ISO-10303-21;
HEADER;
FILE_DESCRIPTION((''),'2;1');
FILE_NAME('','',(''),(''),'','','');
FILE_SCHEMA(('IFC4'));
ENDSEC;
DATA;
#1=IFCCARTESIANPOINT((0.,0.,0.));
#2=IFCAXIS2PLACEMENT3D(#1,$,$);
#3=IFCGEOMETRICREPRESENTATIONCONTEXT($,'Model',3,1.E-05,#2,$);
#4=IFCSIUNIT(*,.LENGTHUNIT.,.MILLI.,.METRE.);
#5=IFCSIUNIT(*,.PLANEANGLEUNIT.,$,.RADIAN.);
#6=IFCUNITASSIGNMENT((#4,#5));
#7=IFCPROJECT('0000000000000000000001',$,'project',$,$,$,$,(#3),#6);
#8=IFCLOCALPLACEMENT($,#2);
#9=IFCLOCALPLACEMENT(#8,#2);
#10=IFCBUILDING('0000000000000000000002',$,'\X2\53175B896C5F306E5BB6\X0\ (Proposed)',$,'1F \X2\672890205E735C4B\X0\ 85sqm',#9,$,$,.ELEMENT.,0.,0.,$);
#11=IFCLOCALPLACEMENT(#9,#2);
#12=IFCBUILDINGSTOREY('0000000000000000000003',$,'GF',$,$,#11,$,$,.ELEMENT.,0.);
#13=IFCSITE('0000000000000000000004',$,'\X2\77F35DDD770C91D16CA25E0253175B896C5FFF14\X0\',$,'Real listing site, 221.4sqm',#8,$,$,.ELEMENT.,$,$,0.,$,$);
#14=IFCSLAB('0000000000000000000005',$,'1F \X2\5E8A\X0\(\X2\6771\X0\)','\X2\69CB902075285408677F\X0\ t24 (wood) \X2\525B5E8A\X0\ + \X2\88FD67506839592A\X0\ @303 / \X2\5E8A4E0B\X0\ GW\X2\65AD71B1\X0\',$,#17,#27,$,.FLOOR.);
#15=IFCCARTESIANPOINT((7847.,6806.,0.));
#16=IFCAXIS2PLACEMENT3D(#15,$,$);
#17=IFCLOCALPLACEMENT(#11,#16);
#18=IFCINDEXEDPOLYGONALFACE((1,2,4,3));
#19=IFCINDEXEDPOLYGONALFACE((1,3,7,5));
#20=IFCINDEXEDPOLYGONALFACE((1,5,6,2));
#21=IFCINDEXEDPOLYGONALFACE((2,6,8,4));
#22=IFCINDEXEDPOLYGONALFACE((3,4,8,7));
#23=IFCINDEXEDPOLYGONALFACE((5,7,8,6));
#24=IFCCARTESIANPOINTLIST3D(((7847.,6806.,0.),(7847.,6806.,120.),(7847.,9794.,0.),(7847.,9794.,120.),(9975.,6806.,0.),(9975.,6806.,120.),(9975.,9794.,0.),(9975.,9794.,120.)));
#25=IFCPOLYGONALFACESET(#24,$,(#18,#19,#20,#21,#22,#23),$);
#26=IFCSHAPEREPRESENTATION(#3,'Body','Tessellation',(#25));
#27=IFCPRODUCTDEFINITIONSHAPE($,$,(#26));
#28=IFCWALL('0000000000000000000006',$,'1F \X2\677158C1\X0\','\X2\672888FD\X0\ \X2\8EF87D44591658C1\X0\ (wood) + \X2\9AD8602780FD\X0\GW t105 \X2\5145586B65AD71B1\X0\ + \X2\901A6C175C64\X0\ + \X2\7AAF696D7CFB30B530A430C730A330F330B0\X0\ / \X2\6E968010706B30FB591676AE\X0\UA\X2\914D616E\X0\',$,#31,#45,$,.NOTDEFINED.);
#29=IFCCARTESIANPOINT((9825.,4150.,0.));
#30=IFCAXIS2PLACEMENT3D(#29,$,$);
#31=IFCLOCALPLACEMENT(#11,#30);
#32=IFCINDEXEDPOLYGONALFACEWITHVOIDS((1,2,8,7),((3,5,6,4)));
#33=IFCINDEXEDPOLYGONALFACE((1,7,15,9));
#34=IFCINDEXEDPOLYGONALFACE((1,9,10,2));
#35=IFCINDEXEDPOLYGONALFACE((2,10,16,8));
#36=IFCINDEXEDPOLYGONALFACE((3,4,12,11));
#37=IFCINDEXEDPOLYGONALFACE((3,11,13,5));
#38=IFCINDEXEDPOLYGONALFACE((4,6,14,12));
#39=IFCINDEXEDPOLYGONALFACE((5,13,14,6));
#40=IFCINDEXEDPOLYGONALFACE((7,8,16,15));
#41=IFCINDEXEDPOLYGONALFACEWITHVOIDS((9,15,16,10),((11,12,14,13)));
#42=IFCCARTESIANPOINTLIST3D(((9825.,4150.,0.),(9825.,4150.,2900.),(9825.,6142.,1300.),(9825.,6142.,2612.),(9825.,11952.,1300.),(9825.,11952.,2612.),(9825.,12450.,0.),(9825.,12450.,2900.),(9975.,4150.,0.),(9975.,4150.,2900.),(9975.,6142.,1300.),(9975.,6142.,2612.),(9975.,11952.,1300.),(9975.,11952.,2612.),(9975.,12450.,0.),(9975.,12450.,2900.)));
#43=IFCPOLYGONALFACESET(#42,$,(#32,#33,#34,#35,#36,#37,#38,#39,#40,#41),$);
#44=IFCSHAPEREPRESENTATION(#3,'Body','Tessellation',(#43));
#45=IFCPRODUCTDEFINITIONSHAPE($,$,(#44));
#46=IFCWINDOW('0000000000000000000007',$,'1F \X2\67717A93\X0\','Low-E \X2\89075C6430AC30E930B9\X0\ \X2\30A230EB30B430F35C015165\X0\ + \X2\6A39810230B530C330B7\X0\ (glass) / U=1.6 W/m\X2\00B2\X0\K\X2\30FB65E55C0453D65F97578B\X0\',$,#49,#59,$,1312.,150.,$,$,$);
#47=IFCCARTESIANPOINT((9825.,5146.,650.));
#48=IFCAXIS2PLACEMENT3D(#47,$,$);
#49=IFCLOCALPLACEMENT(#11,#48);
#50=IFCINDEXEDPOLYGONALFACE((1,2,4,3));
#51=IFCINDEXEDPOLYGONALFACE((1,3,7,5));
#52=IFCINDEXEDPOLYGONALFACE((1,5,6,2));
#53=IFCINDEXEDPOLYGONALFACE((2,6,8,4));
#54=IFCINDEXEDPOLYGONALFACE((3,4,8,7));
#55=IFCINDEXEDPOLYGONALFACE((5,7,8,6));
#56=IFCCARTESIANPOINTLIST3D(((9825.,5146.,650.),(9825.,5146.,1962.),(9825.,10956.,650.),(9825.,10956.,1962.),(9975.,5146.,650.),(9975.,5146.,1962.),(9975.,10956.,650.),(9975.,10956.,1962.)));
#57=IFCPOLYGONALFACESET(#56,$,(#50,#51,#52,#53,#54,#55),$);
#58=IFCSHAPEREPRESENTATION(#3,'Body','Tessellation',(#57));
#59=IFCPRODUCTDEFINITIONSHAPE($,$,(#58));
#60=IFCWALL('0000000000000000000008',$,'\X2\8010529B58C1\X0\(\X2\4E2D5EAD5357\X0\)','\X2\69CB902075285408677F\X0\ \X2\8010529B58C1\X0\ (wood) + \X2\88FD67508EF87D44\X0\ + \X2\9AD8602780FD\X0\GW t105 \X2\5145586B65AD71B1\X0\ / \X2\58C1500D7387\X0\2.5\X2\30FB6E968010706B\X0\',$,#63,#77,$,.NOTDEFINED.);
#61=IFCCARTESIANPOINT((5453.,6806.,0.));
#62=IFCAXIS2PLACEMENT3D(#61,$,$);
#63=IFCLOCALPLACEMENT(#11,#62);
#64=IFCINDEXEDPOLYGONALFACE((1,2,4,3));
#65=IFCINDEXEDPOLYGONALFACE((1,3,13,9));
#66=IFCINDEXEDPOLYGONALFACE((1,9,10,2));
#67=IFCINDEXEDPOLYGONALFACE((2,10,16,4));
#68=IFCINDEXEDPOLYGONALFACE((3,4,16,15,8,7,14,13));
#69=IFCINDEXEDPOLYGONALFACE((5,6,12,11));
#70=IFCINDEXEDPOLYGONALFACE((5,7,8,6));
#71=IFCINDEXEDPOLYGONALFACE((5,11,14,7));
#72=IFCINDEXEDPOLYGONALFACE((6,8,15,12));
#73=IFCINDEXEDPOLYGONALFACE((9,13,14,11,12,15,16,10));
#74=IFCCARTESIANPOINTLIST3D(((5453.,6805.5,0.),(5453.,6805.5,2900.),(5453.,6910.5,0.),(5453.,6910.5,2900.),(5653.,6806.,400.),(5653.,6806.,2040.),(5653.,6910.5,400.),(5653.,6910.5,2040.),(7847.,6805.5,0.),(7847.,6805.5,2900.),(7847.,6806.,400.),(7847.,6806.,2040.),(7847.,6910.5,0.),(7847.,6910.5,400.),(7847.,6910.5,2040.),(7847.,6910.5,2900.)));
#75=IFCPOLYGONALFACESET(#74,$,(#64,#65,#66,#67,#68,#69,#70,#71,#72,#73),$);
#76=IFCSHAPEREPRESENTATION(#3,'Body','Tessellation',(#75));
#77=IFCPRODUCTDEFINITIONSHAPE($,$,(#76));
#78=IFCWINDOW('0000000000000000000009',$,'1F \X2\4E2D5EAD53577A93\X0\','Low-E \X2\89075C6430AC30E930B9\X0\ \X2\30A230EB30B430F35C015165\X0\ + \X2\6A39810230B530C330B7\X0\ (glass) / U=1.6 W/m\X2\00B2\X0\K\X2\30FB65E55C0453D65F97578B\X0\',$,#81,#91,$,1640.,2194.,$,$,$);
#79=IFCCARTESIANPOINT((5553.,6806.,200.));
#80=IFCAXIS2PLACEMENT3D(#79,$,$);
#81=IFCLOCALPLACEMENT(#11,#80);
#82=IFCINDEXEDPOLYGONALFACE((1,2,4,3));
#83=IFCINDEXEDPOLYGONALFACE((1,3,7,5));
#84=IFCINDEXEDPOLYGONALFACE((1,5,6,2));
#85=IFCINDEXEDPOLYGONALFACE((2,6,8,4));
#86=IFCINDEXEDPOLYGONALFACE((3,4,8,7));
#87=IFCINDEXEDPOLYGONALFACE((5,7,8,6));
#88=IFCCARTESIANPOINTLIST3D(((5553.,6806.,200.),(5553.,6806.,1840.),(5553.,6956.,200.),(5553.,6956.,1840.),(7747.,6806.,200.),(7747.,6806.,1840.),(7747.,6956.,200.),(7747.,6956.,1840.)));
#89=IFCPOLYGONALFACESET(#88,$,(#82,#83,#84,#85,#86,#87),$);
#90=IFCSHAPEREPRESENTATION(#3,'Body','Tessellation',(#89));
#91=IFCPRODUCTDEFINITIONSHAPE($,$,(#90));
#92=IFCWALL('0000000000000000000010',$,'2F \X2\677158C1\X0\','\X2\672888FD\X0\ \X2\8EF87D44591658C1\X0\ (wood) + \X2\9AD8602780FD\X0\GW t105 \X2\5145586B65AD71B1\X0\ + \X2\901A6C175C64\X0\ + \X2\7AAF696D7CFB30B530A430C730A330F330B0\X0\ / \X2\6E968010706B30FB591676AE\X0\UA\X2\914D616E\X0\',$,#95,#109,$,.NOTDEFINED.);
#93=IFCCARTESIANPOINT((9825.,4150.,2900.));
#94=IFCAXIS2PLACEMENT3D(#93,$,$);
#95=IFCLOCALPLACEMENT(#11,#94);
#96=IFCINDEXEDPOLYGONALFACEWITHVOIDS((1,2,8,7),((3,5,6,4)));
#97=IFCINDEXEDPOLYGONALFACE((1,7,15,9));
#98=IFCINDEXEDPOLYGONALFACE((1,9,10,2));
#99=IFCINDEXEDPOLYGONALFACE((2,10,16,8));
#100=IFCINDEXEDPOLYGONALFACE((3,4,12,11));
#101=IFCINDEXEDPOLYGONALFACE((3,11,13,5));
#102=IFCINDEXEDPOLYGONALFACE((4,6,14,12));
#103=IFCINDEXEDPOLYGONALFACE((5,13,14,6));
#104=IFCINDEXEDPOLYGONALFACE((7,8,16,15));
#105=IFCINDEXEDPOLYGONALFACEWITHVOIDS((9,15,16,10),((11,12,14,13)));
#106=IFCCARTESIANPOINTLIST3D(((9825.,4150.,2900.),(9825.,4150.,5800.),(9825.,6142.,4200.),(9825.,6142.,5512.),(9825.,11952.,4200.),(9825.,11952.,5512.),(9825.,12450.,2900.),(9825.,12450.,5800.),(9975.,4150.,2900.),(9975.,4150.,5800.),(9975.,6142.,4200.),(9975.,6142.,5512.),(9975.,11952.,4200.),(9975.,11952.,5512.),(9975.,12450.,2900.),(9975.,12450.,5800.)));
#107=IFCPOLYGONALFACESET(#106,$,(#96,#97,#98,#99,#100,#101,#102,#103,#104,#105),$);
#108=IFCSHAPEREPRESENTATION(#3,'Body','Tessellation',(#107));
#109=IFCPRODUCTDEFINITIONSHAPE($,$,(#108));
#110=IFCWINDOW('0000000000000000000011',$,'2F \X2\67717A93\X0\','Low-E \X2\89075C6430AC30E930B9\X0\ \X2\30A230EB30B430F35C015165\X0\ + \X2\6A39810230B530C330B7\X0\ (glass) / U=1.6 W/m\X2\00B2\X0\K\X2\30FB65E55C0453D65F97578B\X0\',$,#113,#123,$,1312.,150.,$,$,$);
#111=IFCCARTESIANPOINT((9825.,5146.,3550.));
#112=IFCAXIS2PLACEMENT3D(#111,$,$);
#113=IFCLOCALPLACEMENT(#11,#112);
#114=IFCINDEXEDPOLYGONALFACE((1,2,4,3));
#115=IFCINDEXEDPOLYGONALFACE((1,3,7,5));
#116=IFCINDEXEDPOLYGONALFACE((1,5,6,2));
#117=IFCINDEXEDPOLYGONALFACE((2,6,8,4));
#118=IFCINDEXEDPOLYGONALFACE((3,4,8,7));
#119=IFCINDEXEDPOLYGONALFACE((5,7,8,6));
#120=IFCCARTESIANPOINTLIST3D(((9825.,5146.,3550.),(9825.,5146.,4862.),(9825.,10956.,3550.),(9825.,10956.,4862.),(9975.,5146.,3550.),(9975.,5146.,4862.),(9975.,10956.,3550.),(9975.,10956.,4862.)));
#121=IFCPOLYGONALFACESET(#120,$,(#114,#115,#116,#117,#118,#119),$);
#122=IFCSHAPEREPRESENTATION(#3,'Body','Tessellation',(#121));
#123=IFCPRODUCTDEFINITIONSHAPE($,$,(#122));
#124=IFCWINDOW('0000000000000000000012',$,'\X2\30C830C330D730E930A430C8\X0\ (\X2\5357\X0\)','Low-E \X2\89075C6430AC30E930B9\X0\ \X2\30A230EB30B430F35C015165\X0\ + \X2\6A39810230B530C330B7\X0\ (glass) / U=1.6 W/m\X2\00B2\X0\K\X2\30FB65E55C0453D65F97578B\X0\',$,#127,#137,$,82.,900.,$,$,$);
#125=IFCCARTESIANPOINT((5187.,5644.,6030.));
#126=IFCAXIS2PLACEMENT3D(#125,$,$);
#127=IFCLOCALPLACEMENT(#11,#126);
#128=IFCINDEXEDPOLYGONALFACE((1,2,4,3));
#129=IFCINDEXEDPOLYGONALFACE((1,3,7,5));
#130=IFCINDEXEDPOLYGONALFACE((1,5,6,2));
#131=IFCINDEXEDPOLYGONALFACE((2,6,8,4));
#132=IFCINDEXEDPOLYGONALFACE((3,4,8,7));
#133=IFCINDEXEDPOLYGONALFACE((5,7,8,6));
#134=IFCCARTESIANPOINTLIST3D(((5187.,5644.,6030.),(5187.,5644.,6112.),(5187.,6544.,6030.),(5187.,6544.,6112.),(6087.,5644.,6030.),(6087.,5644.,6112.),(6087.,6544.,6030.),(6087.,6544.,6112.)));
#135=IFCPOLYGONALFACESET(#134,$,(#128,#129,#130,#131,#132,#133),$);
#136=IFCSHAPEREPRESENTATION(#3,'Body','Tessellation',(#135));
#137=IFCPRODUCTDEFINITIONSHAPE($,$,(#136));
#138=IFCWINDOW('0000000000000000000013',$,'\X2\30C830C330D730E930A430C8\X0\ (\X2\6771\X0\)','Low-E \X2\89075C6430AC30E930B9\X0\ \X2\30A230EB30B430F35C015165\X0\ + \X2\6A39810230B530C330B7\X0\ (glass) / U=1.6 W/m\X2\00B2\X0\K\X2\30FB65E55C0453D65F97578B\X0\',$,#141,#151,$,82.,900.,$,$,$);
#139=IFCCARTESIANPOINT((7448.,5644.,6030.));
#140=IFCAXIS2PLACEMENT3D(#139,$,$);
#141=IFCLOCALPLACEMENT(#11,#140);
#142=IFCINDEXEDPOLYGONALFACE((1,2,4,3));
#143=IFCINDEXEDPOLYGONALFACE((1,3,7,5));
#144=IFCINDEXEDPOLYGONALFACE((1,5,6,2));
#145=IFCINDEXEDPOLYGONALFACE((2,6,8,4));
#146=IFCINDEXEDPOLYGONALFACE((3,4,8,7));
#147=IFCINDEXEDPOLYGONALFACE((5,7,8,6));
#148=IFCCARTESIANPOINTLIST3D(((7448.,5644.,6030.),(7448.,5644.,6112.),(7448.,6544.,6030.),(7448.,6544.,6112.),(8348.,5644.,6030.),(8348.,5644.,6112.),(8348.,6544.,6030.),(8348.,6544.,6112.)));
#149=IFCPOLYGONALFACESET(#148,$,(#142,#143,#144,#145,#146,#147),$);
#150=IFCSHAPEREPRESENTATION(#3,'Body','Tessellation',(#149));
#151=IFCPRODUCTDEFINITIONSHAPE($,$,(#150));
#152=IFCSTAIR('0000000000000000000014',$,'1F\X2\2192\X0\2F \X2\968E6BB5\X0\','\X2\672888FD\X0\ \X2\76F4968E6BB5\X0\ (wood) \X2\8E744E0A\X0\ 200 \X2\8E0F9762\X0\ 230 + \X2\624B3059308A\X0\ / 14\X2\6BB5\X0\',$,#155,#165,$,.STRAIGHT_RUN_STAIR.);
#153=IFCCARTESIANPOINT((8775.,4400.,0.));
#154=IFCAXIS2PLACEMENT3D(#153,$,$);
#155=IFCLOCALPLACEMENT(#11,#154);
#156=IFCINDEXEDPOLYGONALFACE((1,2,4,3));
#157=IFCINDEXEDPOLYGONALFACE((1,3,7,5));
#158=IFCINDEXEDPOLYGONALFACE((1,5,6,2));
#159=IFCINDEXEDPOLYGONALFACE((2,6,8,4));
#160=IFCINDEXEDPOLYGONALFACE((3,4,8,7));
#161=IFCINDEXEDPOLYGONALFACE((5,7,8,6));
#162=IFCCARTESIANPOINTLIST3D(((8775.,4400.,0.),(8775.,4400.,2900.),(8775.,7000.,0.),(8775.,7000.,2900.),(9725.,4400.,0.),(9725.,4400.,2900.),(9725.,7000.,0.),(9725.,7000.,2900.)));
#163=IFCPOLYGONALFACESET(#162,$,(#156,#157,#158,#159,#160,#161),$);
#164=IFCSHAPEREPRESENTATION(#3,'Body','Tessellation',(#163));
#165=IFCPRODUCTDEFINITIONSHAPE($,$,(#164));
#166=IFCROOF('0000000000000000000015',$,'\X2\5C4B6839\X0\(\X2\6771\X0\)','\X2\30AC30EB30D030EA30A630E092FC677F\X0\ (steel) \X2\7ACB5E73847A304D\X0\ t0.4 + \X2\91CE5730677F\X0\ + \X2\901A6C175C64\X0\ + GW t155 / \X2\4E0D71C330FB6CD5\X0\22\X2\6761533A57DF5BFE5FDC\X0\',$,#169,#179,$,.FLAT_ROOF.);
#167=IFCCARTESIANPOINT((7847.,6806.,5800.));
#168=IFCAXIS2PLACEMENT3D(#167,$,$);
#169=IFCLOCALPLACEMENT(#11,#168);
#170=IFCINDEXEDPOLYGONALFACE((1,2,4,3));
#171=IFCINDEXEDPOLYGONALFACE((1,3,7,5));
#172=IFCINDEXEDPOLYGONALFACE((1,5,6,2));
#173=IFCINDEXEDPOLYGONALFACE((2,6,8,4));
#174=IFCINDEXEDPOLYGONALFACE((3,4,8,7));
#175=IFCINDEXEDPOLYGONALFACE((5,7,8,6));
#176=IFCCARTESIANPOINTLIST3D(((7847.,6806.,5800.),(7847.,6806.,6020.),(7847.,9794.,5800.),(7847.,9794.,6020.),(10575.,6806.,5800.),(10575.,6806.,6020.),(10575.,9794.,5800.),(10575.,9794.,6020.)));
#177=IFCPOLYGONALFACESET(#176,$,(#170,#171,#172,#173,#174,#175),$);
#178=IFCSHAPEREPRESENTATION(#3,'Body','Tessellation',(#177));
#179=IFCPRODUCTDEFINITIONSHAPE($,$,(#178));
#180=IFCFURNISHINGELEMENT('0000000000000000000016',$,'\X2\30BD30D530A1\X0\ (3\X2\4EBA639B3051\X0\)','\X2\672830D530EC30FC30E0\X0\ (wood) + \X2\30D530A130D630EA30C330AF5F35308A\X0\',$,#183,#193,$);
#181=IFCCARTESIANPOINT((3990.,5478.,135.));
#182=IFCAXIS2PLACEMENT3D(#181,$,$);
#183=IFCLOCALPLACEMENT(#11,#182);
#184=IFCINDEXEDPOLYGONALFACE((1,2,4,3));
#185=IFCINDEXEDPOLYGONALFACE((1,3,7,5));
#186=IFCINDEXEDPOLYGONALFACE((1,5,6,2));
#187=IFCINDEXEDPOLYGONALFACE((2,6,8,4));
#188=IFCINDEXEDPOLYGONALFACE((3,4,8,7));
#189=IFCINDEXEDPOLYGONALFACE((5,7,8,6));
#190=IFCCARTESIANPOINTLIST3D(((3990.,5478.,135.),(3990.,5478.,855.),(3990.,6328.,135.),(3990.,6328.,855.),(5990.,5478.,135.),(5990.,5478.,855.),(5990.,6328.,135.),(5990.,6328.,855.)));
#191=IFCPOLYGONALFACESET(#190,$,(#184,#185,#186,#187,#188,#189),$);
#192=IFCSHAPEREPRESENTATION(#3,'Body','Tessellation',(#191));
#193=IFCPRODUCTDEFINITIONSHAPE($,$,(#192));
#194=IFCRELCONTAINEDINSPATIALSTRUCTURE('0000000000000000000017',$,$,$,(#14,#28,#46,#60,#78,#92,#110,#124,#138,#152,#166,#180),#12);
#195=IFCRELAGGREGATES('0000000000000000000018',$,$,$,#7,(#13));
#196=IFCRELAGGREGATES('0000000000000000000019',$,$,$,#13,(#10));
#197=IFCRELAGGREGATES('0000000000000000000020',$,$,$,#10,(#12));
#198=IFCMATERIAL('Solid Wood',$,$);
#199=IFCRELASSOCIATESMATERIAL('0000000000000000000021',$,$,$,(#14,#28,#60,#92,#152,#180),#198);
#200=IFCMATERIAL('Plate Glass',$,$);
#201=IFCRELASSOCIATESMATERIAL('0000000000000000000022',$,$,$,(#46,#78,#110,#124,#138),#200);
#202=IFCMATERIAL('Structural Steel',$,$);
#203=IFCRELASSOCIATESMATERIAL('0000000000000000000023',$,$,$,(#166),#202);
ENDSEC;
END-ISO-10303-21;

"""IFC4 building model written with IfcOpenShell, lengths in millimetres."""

from ifc_helpers import new_model, si_unit, frame, frame_2d, origin, place, context, project, spatial, rectangle, extrude, material, element, fill, save


model = new_model("IFC4")

# Units and contexts
model_context = context("Model", 3, precision=1e-05, world=origin())
ifc_project = project(units=[si_unit("LENGTHUNIT", "METRE", prefix="MILLI"), si_unit("PLANEANGLEUNIT", "RADIAN")], contexts=[model_context])

# Site, building, storey
site_placement = place(None, origin())
site = spatial("IfcSite", under=ifc_project, at=site_placement, Name="石川県金沢市北安江４", ObjectType="Real listing site, 221.4sqm", CompositionType="ELEMENT", RefElevation=0.0)
building_placement = place(site_placement, origin())
building = spatial("IfcBuilding", under=site, at=building_placement, Name="北安江の家 (Proposed)", ObjectType="1F 木造平屋 85sqm", CompositionType="ELEMENT", ElevationOfRefHeight=0.0, ElevationOfTerrain=0.0)
storey_placement = place(building_placement, origin())
storey = spatial("IfcBuildingStorey", under=building, at=storey_placement, Name="GF", CompositionType="ELEMENT", Elevation=0.0)

# Slab
ifc_material_1 = material(Name="Solid Wood")
slab_placement = place(storey_placement, frame((7847.0, 6806.0, 0.0)))
element("IfcSlab", 1, at=slab_placement, inside=storey, material=ifc_material_1, Name="1F 床(東)", Description="構造用合板 t24 (wood) 剛床 + 製材根太 @303 / 床下 GW断熱", PredefinedType="FLOOR", context=model_context, shape_type="SweptSolid", body=[
    extrude(rectangle(XDim=2128.0, YDim=2988.0, at=frame_2d((1064.0, 1494.0))), frame((7847.0, 6806.0, 0.0)), (0.0, 0.0, 1.0), 120.0),
])

# Walls, openings, windows
wall_1_placement = place(storey_placement, frame((9825.0, 4150.0, 0.0)))
wall_1 = element("IfcWall", 2, at=wall_1_placement, inside=storey, material=ifc_material_1, Name="1F 東壁", Description="木製 軸組外壁 (wood) + 高性能GW t105 充填断熱 + 通気層 + 窯業系サイディング / 準耐火・外皮UA配慮", PredefinedType="NOTDEFINED", context=model_context, shape_type="SweptSolid", body=[
    extrude(rectangle(XDim=150.0, YDim=8300.0, at=frame_2d((75.0, 4150.0))), frame((9825.0, 4150.0, 0.0)), (0.0, 0.0, 1.0), 2900.0),
])
opening_1_placement = place(storey_placement, frame((9825.0, 5146.0, 650.0)))
opening_1 = element("IfcOpeningElement", 3, at=opening_1_placement, cuts=wall_1, PredefinedType="NOTDEFINED", context=model_context, shape_type="SweptSolid", body=[
    extrude(rectangle(XDim=150.0, YDim=5810.0, at=frame_2d((75.0, 2905.0))), frame((9825.0, 5146.0, 650.0)), (0.0, 0.0, 1.0), 1312.0),
])
ifc_material_2 = material(Name="Plate Glass")
window_1_placement = place(storey_placement, frame((9825.0, 5146.0, 650.0)))
window_1 = element("IfcWindow", 4, at=window_1_placement, inside=storey, material=ifc_material_2, Name="1F 東窓", Description="Low-E 複層ガラス アルゴン封入 + 樹脂サッシ (glass) / U=1.6 W/m²K・日射取得型", OverallHeight=1312.0, OverallWidth=150.0, context=model_context, shape_type="SweptSolid", body=[
    extrude(rectangle(XDim=150.0, YDim=5810.0, at=frame_2d((75.0, 2905.0))), frame((9825.0, 5146.0, 650.0)), (0.0, 0.0, 1.0), 1312.0),
])
fill(opening_1, window_1)
wall_2_placement = place(storey_placement, frame((5453.0, 6806.0, 0.0)))
wall_2 = element("IfcWall", 5, at=wall_2_placement, inside=storey, material=ifc_material_1, Name="耐力壁(中庭南)", Description="構造用合板 耐力壁 (wood) + 製材軸組 + 高性能GW t105 充填断熱 / 壁倍率2.5・準耐火", PredefinedType="NOTDEFINED", context=model_context, shape_type="SweptSolid", body=[
    extrude(rectangle(XDim=2394.0, YDim=105.0, at=frame_2d((1197.0, 52.0))), frame((5453.0, 6806.0, 0.0)), (0.0, 0.0, 1.0), 2900.0),
])
opening_2_placement = place(storey_placement, frame((5553.0, 6806.0, 200.0)))
opening_2 = element("IfcOpeningElement", 6, at=opening_2_placement, cuts=wall_2, PredefinedType="NOTDEFINED", context=model_context, shape_type="SweptSolid", body=[
    extrude(rectangle(XDim=2194.0, YDim=150.0, at=frame_2d((1097.0, 75.0))), frame((5553.0, 6806.0, 200.0)), (0.0, 0.0, 1.0), 1640.0),
])
window_2_placement = place(storey_placement, frame((5553.0, 6806.0, 200.0)))
window_2 = element("IfcWindow", 7, at=window_2_placement, inside=storey, material=ifc_material_2, Name="1F 中庭南窓", Description="Low-E 複層ガラス アルゴン封入 + 樹脂サッシ (glass) / U=1.6 W/m²K・日射取得型", OverallHeight=1640.0, OverallWidth=2194.0, context=model_context, shape_type="SweptSolid", body=[
    extrude(rectangle(XDim=2194.0, YDim=150.0, at=frame_2d((1097.0, 75.0))), frame((5553.0, 6806.0, 200.0)), (0.0, 0.0, 1.0), 1640.0),
])
fill(opening_2, window_2)

# Wall, opening, window
wall_3_placement = place(storey_placement, frame((9825.0, 4150.0, 2900.0)))
wall_3 = element("IfcWall", 8, at=wall_3_placement, inside=storey, material=ifc_material_1, Name="2F 東壁", Description="木製 軸組外壁 (wood) + 高性能GW t105 充填断熱 + 通気層 + 窯業系サイディング / 準耐火・外皮UA配慮", PredefinedType="NOTDEFINED", context=model_context, shape_type="SweptSolid", body=[
    extrude(rectangle(XDim=150.0, YDim=8300.0, at=frame_2d((75.0, 4150.0))), frame((9825.0, 4150.0, 2900.0)), (0.0, 0.0, 1.0), 2900.0),
])
opening_3_placement = place(storey_placement, frame((9825.0, 5146.0, 3550.0)))
opening_3 = element("IfcOpeningElement", 9, at=opening_3_placement, cuts=wall_3, PredefinedType="NOTDEFINED", context=model_context, shape_type="SweptSolid", body=[
    extrude(rectangle(XDim=150.0, YDim=5810.0, at=frame_2d((75.0, 2905.0))), frame((9825.0, 5146.0, 3550.0)), (0.0, 0.0, 1.0), 1312.0),
])
window_3_placement = place(storey_placement, frame((9825.0, 5146.0, 3550.0)))
window_3 = element("IfcWindow", 10, at=window_3_placement, inside=storey, material=ifc_material_2, Name="2F 東窓", Description="Low-E 複層ガラス アルゴン封入 + 樹脂サッシ (glass) / U=1.6 W/m²K・日射取得型", OverallHeight=1312.0, OverallWidth=150.0, context=model_context, shape_type="SweptSolid", body=[
    extrude(rectangle(XDim=150.0, YDim=5810.0, at=frame_2d((75.0, 2905.0))), frame((9825.0, 5146.0, 3550.0)), (0.0, 0.0, 1.0), 1312.0),
])
fill(opening_3, window_3)

# Windows
window_4_placement = place(storey_placement, frame((5187.0, 5644.0, 6030.0)))
element("IfcWindow", 11, at=window_4_placement, inside=storey, material=ifc_material_2, Name="トップライト (南)", Description="Low-E 複層ガラス アルゴン封入 + 樹脂サッシ (glass) / U=1.6 W/m²K・日射取得型", OverallHeight=82.0, OverallWidth=900.0, context=model_context, shape_type="SweptSolid", body=[
    extrude(rectangle(XDim=900.0, YDim=900.0, at=frame_2d((450.0, 450.0))), frame((5187.0, 5644.0, 6030.0)), (0.0, 0.0, 1.0), 82.0),
])
window_5_placement = place(storey_placement, frame((7448.0, 5644.0, 6030.0)))
element("IfcWindow", 12, at=window_5_placement, inside=storey, material=ifc_material_2, Name="トップライト (東)", Description="Low-E 複層ガラス アルゴン封入 + 樹脂サッシ (glass) / U=1.6 W/m²K・日射取得型", OverallHeight=82.0, OverallWidth=900.0, context=model_context, shape_type="SweptSolid", body=[
    extrude(rectangle(XDim=900.0, YDim=900.0, at=frame_2d((450.0, 450.0))), frame((7448.0, 5644.0, 6030.0)), (0.0, 0.0, 1.0), 82.0),
])

# Stair
stair_placement = place(storey_placement, frame((8775.0, 4400.0, 0.0)))
element("IfcStair", 13, at=stair_placement, inside=storey, material=ifc_material_1, Name="1F→2F 階段", Description="木製 直階段 (wood) 蹴上 200 踏面 230 + 手すり / 14段", PredefinedType="STRAIGHT_RUN_STAIR", context=model_context, shape_type="SweptSolid", body=[
    extrude(rectangle(XDim=950.0, YDim=2600.0, at=frame_2d((475.0, 1300.0))), frame((8775.0, 4400.0, 0.0)), (0.0, 0.0, 1.0), 2900.0),
])

# Roof
ifc_material_3 = material(Name="Structural Steel")
roof_placement = place(storey_placement, frame((7847.0, 6806.0, 5800.0)))
element("IfcRoof", 14, at=roof_placement, inside=storey, material=ifc_material_3, Name="屋根(東)", Description="ガルバリウム鋼板 (steel) 立平葺き t0.4 + 野地板 + 通気層 + GW t155 / 不燃・法22条区域対応", PredefinedType="FLAT_ROOF", context=model_context, shape_type="SweptSolid", body=[
    extrude(rectangle(XDim=2728.0, YDim=2988.0, at=frame_2d((1364.0, 1494.0))), frame((7847.0, 6806.0, 5800.0)), (0.0, 0.0, 1.0), 220.0),
])

# Furnishing element
furnishing_1_placement = place(storey_placement, frame((3990.0, 5478.0, 135.0)))
element("IfcFurnishingElement", 15, at=furnishing_1_placement, inside=storey, material=ifc_material_1, Name="ソファ (3人掛け)", Description="木フレーム (wood) + ファブリック張り", context=model_context, shape_type="SweptSolid", body=[
    extrude(rectangle(XDim=2000.0, YDim=850.0, at=frame_2d((1000.0, 425.0))), frame((3990.0, 5478.0, 135.0)), (0.0, 0.0, 1.0), 720.0),
])

save(model, "model.ifc")
